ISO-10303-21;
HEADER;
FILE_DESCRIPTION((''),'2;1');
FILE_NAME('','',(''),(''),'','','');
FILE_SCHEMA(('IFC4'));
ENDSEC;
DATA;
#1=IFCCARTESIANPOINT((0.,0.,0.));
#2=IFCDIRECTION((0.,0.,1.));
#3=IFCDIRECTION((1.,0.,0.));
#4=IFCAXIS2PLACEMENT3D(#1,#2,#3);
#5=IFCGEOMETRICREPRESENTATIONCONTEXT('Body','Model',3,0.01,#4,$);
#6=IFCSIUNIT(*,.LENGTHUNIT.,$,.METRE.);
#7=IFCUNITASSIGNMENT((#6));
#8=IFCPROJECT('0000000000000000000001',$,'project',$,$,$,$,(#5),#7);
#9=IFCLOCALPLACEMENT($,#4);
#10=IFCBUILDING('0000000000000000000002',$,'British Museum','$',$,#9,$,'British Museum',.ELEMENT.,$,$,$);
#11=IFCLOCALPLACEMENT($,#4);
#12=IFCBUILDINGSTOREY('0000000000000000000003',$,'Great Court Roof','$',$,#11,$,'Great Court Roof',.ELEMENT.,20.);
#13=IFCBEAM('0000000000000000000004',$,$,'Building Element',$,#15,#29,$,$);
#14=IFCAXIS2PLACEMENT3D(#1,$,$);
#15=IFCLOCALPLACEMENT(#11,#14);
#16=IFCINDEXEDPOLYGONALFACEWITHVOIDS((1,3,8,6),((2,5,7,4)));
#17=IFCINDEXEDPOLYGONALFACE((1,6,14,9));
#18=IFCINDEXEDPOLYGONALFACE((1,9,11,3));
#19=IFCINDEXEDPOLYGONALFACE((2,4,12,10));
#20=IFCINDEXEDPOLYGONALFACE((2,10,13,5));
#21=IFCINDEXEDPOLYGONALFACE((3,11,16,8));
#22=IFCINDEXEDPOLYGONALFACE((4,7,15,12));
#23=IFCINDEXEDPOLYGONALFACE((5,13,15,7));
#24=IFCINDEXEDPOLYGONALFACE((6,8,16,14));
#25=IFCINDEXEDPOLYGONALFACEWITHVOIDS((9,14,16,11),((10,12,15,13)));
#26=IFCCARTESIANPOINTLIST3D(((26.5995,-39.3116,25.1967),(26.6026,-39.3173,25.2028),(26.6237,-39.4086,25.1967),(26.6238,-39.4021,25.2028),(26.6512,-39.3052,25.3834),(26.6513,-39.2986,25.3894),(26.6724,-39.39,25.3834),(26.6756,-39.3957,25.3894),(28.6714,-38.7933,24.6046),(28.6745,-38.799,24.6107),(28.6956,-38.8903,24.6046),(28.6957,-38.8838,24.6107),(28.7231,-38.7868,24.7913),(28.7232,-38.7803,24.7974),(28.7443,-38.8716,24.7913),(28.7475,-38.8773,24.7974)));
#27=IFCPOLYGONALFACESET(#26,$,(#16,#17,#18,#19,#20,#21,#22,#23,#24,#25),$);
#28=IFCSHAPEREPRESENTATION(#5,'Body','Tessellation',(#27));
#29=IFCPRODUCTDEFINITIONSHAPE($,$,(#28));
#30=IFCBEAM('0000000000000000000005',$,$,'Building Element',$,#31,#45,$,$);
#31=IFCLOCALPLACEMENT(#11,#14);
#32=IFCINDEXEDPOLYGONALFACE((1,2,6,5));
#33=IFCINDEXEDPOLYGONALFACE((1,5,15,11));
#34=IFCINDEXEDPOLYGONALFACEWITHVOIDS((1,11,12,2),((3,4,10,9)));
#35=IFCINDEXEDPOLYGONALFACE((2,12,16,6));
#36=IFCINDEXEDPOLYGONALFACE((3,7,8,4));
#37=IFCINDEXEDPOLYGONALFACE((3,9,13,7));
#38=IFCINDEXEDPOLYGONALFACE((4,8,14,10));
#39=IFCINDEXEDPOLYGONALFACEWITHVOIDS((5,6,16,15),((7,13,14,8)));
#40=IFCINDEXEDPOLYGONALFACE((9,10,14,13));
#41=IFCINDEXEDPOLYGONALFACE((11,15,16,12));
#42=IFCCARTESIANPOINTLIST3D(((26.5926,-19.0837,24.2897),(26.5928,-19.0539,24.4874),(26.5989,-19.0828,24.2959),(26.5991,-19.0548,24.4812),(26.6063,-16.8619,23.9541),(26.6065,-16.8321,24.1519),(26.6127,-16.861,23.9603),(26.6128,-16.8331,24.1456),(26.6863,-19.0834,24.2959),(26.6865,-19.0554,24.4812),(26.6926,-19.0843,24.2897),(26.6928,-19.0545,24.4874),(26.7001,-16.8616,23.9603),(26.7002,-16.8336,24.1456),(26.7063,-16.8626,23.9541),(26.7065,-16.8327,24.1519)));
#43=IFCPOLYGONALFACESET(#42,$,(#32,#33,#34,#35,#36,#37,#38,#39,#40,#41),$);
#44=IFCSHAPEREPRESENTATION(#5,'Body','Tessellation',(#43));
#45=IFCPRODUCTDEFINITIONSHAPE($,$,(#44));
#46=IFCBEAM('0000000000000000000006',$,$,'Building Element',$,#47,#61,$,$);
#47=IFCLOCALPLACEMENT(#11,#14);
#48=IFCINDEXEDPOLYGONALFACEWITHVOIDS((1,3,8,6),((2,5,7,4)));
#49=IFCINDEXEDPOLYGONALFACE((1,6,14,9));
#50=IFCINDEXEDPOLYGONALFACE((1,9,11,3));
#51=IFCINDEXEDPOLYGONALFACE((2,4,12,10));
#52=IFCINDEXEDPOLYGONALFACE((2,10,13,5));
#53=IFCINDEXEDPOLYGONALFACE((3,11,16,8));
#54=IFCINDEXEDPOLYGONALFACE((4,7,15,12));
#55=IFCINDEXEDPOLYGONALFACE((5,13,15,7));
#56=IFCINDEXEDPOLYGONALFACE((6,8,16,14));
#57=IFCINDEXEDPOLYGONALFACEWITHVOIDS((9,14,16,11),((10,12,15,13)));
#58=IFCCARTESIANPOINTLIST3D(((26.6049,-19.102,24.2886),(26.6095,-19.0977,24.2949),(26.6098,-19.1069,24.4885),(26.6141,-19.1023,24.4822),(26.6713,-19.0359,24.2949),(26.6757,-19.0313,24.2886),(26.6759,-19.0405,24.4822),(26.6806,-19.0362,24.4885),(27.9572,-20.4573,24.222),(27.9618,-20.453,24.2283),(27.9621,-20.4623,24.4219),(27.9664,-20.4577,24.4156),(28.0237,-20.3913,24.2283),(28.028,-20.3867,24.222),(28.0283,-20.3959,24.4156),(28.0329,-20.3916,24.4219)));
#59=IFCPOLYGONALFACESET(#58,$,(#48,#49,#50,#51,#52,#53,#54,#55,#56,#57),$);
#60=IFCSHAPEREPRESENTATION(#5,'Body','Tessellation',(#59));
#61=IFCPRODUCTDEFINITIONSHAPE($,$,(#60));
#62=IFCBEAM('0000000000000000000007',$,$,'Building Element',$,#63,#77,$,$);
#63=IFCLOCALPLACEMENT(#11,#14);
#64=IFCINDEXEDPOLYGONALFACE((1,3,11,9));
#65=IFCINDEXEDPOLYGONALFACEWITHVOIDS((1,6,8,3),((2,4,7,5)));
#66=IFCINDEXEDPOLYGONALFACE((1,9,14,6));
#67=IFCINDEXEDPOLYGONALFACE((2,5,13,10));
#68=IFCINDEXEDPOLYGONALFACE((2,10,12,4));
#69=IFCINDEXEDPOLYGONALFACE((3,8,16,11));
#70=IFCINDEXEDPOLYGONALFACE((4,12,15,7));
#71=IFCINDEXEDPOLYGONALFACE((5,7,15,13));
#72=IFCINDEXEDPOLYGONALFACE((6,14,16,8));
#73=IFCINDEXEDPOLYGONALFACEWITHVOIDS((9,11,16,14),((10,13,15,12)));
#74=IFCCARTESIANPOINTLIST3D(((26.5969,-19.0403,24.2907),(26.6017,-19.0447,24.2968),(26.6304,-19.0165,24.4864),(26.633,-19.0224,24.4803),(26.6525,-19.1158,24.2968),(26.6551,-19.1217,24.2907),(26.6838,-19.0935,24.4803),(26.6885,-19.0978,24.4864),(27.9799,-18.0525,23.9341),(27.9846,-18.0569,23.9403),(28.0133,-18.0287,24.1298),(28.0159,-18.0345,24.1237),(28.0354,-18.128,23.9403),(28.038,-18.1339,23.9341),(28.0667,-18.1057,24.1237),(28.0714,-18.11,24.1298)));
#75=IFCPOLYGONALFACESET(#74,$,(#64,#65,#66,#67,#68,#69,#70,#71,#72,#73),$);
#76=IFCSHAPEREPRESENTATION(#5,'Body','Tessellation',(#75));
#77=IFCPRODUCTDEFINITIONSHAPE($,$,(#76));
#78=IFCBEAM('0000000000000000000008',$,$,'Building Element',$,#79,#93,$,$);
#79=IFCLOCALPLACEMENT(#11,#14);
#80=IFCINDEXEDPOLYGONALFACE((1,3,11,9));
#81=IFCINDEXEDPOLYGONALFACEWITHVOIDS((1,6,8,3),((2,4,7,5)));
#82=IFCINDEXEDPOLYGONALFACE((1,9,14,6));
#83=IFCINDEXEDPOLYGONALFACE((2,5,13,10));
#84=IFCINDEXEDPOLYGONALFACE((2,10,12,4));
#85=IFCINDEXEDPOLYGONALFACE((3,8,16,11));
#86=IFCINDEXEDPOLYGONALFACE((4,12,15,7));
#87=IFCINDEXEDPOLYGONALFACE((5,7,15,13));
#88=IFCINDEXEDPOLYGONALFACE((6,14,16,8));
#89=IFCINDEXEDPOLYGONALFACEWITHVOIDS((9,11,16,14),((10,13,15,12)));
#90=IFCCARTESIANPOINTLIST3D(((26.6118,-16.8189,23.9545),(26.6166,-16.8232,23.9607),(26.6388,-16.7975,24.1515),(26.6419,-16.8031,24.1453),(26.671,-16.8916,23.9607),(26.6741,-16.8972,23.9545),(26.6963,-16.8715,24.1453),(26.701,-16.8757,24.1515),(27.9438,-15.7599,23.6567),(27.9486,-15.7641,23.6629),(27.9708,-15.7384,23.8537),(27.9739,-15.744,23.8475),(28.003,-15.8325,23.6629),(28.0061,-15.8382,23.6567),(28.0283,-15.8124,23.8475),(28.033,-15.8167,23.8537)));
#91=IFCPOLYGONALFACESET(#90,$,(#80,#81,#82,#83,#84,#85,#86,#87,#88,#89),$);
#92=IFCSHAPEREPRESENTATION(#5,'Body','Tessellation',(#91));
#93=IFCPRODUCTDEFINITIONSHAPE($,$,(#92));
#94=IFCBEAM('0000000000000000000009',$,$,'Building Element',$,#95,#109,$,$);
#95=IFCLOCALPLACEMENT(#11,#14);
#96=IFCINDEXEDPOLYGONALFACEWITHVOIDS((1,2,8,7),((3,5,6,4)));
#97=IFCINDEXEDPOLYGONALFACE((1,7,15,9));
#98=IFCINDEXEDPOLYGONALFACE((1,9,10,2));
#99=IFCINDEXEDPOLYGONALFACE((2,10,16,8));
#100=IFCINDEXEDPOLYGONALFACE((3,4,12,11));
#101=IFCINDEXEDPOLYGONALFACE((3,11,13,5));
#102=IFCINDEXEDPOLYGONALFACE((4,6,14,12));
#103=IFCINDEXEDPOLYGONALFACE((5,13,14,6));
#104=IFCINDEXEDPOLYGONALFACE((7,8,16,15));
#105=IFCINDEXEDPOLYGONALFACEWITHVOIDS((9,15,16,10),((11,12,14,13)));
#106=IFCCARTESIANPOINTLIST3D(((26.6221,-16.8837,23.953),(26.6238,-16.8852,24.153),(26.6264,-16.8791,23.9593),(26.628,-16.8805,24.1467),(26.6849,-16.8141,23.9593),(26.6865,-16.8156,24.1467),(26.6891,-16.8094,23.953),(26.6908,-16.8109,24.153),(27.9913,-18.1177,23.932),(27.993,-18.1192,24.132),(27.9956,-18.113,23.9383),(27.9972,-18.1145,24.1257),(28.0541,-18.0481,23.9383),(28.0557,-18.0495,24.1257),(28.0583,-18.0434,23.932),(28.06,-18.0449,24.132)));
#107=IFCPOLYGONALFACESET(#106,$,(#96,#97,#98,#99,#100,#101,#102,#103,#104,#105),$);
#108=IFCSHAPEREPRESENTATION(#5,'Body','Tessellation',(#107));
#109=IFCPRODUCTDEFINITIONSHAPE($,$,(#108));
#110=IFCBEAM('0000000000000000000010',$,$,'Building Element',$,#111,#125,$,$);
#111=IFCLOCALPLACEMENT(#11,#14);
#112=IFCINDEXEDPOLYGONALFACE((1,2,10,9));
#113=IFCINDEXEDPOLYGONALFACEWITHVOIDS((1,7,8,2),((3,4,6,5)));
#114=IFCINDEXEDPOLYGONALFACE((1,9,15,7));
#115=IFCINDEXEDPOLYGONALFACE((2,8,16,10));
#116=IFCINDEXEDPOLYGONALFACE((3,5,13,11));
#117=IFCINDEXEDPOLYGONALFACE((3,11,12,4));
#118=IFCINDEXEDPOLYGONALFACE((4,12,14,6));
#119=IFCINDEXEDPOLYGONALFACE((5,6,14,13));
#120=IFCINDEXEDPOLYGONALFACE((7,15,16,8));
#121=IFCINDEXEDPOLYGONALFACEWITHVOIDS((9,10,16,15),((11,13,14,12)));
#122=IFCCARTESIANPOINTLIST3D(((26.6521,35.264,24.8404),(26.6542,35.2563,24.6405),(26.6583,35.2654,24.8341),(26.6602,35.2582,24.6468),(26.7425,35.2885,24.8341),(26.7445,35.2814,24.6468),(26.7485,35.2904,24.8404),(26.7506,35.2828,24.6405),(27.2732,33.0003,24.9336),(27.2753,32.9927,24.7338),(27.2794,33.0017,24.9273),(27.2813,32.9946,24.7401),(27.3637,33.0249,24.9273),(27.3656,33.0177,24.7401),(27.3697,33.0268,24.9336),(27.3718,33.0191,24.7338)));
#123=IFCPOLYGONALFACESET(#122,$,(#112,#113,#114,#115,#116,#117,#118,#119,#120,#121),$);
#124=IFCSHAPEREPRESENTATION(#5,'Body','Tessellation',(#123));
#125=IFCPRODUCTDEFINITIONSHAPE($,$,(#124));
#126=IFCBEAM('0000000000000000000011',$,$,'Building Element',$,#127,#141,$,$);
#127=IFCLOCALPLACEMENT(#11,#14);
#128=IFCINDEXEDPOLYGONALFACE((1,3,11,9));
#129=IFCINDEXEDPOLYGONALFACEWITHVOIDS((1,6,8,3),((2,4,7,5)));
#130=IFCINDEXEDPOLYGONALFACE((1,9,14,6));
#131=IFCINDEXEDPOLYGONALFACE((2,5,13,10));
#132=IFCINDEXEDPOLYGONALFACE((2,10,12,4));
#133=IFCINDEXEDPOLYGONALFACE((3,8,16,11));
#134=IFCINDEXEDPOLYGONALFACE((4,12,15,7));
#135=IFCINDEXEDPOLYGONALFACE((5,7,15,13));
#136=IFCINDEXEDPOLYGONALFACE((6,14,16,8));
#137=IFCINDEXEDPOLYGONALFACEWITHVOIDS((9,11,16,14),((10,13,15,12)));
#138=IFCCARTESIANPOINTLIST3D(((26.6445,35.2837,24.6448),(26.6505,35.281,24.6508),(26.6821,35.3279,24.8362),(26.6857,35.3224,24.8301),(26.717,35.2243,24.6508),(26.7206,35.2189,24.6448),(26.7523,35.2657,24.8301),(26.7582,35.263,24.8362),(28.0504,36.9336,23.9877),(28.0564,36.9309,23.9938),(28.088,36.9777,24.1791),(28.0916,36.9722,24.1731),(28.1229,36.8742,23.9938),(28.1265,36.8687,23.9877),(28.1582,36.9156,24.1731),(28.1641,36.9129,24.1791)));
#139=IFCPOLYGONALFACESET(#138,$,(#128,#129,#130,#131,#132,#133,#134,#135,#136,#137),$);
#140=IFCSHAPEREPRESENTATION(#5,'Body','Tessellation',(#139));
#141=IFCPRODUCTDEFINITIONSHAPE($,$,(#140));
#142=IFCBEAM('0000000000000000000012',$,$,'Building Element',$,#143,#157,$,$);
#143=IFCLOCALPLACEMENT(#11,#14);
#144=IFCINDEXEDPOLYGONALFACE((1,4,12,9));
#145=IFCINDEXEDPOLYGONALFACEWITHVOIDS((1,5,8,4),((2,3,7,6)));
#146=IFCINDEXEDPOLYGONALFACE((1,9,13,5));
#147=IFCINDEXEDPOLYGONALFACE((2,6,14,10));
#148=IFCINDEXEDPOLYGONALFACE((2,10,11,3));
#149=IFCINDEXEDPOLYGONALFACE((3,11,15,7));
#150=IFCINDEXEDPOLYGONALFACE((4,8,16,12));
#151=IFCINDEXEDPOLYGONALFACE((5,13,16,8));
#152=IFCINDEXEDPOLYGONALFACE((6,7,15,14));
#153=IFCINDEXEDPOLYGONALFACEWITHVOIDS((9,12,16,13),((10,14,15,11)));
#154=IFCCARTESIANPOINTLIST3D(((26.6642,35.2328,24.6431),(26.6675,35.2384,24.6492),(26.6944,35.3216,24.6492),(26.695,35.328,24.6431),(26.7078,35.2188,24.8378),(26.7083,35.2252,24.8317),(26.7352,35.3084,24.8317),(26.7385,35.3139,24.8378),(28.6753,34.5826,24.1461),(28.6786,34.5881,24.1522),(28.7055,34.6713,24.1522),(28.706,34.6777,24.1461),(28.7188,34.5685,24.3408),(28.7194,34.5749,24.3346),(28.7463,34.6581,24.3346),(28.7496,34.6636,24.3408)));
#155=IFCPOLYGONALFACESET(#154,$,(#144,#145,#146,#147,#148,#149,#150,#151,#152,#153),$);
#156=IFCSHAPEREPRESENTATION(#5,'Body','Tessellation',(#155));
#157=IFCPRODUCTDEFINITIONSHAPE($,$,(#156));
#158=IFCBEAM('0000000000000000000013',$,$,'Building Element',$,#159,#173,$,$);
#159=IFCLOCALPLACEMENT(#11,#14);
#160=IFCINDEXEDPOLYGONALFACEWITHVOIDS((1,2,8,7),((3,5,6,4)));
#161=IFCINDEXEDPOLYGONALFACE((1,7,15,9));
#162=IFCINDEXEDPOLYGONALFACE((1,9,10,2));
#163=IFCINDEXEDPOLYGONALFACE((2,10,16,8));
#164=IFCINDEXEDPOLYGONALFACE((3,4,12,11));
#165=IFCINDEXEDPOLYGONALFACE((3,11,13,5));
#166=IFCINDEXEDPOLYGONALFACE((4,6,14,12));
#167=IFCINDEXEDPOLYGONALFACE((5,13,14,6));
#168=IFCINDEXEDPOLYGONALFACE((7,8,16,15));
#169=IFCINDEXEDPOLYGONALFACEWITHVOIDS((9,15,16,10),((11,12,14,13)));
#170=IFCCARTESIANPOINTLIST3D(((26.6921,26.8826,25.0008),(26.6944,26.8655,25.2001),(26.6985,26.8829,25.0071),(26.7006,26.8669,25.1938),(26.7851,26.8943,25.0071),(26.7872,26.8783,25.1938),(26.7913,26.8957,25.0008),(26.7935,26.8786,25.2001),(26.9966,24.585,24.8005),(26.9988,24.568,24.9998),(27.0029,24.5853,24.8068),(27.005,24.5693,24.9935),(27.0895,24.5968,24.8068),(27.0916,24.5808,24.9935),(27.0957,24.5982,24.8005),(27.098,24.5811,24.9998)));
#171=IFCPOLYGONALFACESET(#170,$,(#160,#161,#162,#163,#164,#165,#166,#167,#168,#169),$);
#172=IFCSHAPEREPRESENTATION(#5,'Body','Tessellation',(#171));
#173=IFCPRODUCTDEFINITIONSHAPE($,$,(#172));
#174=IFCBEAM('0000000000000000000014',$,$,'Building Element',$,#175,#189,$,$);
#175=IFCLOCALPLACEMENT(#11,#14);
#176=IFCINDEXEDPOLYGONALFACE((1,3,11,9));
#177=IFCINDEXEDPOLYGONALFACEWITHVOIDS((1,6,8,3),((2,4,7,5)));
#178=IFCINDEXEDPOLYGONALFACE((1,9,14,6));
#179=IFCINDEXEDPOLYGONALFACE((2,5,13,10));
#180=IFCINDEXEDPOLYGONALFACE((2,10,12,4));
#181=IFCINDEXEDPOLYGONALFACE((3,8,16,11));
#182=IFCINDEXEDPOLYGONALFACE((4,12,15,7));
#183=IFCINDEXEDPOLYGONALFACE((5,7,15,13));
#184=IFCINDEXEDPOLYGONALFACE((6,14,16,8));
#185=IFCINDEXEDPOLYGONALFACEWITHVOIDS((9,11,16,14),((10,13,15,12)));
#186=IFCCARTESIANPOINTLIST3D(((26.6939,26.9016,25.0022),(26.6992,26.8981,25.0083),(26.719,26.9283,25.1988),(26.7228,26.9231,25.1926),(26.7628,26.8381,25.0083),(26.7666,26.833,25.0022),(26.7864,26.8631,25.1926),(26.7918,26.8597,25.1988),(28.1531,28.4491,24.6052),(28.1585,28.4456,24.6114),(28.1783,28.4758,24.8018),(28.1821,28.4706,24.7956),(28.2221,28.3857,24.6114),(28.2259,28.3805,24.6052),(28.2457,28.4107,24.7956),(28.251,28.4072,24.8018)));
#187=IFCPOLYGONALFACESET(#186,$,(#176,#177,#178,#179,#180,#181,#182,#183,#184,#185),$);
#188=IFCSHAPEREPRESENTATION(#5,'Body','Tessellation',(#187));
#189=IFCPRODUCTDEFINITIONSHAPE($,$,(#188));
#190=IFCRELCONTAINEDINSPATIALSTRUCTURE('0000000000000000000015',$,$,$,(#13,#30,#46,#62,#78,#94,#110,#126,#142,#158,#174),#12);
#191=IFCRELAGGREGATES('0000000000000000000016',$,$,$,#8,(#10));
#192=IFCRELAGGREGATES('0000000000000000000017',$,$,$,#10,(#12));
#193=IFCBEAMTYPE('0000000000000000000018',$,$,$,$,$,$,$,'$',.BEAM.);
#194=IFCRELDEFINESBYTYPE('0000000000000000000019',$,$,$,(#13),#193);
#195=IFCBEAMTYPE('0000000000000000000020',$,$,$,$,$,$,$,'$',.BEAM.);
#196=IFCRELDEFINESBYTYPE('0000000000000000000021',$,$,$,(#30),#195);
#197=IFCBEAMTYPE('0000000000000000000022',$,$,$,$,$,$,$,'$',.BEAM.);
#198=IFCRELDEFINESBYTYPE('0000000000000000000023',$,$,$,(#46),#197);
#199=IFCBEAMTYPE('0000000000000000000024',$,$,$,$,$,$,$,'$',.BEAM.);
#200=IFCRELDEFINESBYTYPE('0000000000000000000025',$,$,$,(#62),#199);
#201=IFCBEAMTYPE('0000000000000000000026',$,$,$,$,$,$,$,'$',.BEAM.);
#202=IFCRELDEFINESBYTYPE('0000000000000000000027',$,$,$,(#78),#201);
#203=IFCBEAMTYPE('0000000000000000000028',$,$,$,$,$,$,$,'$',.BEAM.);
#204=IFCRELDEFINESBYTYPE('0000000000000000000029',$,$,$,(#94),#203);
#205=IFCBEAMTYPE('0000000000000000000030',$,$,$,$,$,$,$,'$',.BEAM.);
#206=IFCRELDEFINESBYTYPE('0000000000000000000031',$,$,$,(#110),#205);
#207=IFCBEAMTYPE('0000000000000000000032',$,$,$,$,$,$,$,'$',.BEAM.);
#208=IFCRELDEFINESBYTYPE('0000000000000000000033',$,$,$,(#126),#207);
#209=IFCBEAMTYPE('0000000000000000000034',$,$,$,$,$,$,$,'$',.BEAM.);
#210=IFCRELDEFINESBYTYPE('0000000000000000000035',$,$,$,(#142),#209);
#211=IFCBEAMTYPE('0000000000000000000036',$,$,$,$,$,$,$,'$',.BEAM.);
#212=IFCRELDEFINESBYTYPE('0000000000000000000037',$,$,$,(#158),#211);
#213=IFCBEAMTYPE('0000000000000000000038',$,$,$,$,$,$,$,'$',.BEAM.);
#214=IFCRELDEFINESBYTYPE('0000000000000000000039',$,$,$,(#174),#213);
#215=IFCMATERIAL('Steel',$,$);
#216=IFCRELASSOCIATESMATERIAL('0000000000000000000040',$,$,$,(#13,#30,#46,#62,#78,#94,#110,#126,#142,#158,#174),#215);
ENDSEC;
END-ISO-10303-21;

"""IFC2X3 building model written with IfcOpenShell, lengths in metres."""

from ifc_helpers import new_model, si_unit, frame, origin_with_axes, origin_2d, place, context, project, spatial, hollow_rectangle, extrude, material, type_object, element, save


model = new_model("IFC2X3")

# Units and contexts
model_context = context("Model", 3, precision=0.01, world=origin_with_axes(), identifier="Body")
ifc_project = project(units=[si_unit("LENGTHUNIT", "METRE")], contexts=[model_context])

# Building, storey
building_placement = place(None, origin_with_axes())
building = spatial("IfcBuilding", under=ifc_project, at=building_placement, Name="British Museum", Description="$", LongName="British Museum", CompositionType="ELEMENT")
storey_placement = place(None, origin_with_axes())
storey = spatial("IfcBuildingStorey", under=building, at=storey_placement, Name="Great Court Roof", Description="$", LongName="Great Court Roof", CompositionType="ELEMENT", Elevation=20.0)

# Beams
ifc_material = material(Name="Steel")
beam_type_1 = type_object("IfcBeamType", ElementType="$", PredefinedType="BEAM")
beam_1_placement = place(None, origin_with_axes())
element("IfcBeam", 1, at=beam_1_placement, inside=storey, type_object=beam_type_1, material=ifc_material, Description="Building Element", context=model_context, shape_type="SweptSolid", body=[
    extrude(hollow_rectangle(XDim=0.1, YDim=0.2, WallThickness=0.0063, InnerFilletRadius=0.0, OuterFilletRadius=0.0, at=origin_2d()), frame((26.6375, -39.3536, 25.2931), z_axis=(0.934843, 0.233871, -0.267156), x_axis=(-0.242692, 0.970103, 0.0)), (0.0, 0.0, 1.0), 2.2163),
])
beam_type_2 = type_object("IfcBeamType", ElementType="$", PredefinedType="BEAM")
beam_2_placement = place(None, origin_with_axes())
element("IfcBeam", 2, at=beam_2_placement, inside=storey, type_object=beam_type_2, material=ifc_material, Description="Building Element", context=model_context, shape_type="SweptSolid", body=[
    extrude(hollow_rectangle(XDim=0.1, YDim=0.2, WallThickness=0.0063, InnerFilletRadius=0.0, OuterFilletRadius=0.0, at=origin_2d()), frame((26.6427, -19.0691, 24.3885), z_axis=(0.006109, 0.988767, -0.149339), x_axis=(-0.999981, 0.006178, 0.0)), (0.0, 0.0, 1.0), 2.247),
])
beam_type_3 = type_object("IfcBeamType", ElementType="$", PredefinedType="BEAM")
beam_3_placement = place(None, origin_with_axes())
element("IfcBeam", 3, at=beam_3_placement, inside=storey, type_object=beam_type_3, material=ifc_material, Description="Building Element", context=model_context, shape_type="SweptSolid", body=[
    extrude(hollow_rectangle(XDim=0.1, YDim=0.2, WallThickness=0.0063, InnerFilletRadius=0.0, OuterFilletRadius=0.0, at=origin_2d()), frame((26.6427, -19.0691, 24.3885), z_axis=(0.705882, -0.707477, -0.034746), x_axis=(0.707904, 0.706308, 0.0)), (0.0, 0.0, 1.0), 1.9158),
])
beam_type_4 = type_object("IfcBeamType", ElementType="$", PredefinedType="BEAM")
beam_4_placement = place(None, origin_with_axes())
element("IfcBeam", 4, at=beam_4_placement, inside=storey, type_object=beam_type_4, material=ifc_material, Description="Building Element", context=model_context, shape_type="SweptSolid", body=[
    extrude(hollow_rectangle(XDim=0.1, YDim=0.2, WallThickness=0.0063, InnerFilletRadius=0.0, OuterFilletRadius=0.0, at=origin_2d()), frame((26.6427, -19.0691, 24.3885), z_axis=(0.796387, 0.56886, -0.205342), x_axis=(-0.581246, 0.813728, 0.0)), (0.0, 0.0, 1.0), 1.7365),
])
beam_type_5 = type_object("IfcBeamType", ElementType="$", PredefinedType="BEAM")
beam_5_placement = place(None, origin_with_axes())
element("IfcBeam", 5, at=beam_5_placement, inside=storey, type_object=beam_type_5, material=ifc_material, Description="Building Element", context=model_context, shape_type="SweptSolid", body=[
    extrude(hollow_rectangle(XDim=0.1, YDim=0.2, WallThickness=0.0063, InnerFilletRadius=0.0, OuterFilletRadius=0.0, at=origin_2d()), frame((26.6564, -16.8473, 24.053), z_axis=(0.771038, 0.613023, -0.172347), x_axis=(-0.622335, 0.782751, 0.0)), (0.0, 0.0, 1.0), 1.7275),
])
beam_type_6 = type_object("IfcBeamType", ElementType="$", PredefinedType="BEAM")
beam_6_placement = place(None, origin_with_axes())
element("IfcBeam", 6, at=beam_6_placement, inside=storey, type_object=beam_type_6, material=ifc_material, Description="Building Element", context=model_context, shape_type="SweptSolid", body=[
    extrude(hollow_rectangle(XDim=0.1, YDim=0.2, WallThickness=0.0063, InnerFilletRadius=0.0, OuterFilletRadius=0.0, at=origin_2d()), frame((26.6564, -16.8473, 24.053), z_axis=(0.74279, -0.669427, -0.011396), x_axis=(0.669471, 0.742838, 0.0)), (0.0, 0.0, 1.0), 1.8433),
])
beam_type_7 = type_object("IfcBeamType", ElementType="$", PredefinedType="BEAM")
beam_7_placement = place(None, origin_with_axes())
element("IfcBeam", 7, at=beam_7_placement, inside=storey, type_object=beam_type_7, material=ifc_material, Description="Building Element", context=model_context, shape_type="SweptSolid", body=[
    extrude(hollow_rectangle(XDim=0.1, YDim=0.2, WallThickness=0.0063, InnerFilletRadius=0.0, OuterFilletRadius=0.0, at=origin_2d()), frame((26.7014, 35.2734, 24.7405), z_axis=(0.264396, -0.963597, 0.039687), x_axis=(0.964357, 0.264604, 0.0)), (0.0, 0.0, 1.0), 2.3492),
])
beam_type_8 = type_object("IfcBeamType", ElementType="$", PredefinedType="BEAM")
beam_8_placement = place(None, origin_with_axes())
element("IfcBeam", 8, at=beam_8_placement, inside=storey, type_object=beam_type_8, material=ifc_material, Description="Building Element", context=model_context, shape_type="SweptSolid", body=[
    extrude(hollow_rectangle(XDim=0.1, YDim=0.2, WallThickness=0.0063, InnerFilletRadius=0.0, OuterFilletRadius=0.0, at=origin_2d()), frame((26.7014, 35.2734, 24.7405), z_axis=(0.62071, 0.728406, -0.290076), x_axis=(-0.761132, 0.648597, 0.0)), (0.0, 0.0, 1.0), 2.265),
])
beam_type_9 = type_object("IfcBeamType", ElementType="$", PredefinedType="BEAM")
beam_9_placement = place(None, origin_with_axes())
element("IfcBeam", 9, at=beam_9_placement, inside=storey, type_object=beam_type_9, material=ifc_material, Description="Building Element", context=model_context, shape_type="SweptSolid", body=[
    extrude(hollow_rectangle(XDim=0.1, YDim=0.2, WallThickness=0.0063, InnerFilletRadius=0.0, OuterFilletRadius=0.0, at=origin_2d()), frame((26.7014, 35.2734, 24.7405), z_axis=(0.926229, -0.299493, -0.228917), x_axis=(0.307663, 0.951495, 0.0)), (0.0, 0.0, 1.0), 2.1712),
])
beam_type_10 = type_object("IfcBeamType", ElementType="$", PredefinedType="BEAM")
beam_10_placement = place(None, origin_with_axes())
element("IfcBeam", 10, at=beam_10_placement, inside=storey, type_object=beam_type_10, material=ifc_material, Description="Building Element", context=model_context, shape_type="SweptSolid", body=[
    extrude(hollow_rectangle(XDim=0.1, YDim=0.2, WallThickness=0.0063, InnerFilletRadius=0.0, OuterFilletRadius=0.0, at=origin_2d()), frame((26.7428, 26.8806, 25.1005), z_axis=(0.130869, -0.987653, -0.086113), x_axis=(0.991335, 0.131357, 0.0)), (0.0, 0.0, 1.0), 2.3262),
])
beam_type_11 = type_object("IfcBeamType", ElementType="$", PredefinedType="BEAM")
beam_11_placement = place(None, origin_with_axes())
element("IfcBeam", 11, at=beam_11_placement, inside=storey, type_object=beam_type_11, material=ifc_material, Description="Building Element", context=model_context, shape_type="SweptSolid", body=[
    extrude(hollow_rectangle(XDim=0.1, YDim=0.2, WallThickness=0.0063, InnerFilletRadius=0.0, OuterFilletRadius=0.0, at=origin_2d()), frame((26.7428, 26.8806, 25.1005), z_axis=(0.674399, 0.715211, -0.183464), x_axis=(-0.72756, 0.686044, 0.0)), (0.0, 0.0, 1.0), 2.1638),
])

save(model, "model.ifc")
